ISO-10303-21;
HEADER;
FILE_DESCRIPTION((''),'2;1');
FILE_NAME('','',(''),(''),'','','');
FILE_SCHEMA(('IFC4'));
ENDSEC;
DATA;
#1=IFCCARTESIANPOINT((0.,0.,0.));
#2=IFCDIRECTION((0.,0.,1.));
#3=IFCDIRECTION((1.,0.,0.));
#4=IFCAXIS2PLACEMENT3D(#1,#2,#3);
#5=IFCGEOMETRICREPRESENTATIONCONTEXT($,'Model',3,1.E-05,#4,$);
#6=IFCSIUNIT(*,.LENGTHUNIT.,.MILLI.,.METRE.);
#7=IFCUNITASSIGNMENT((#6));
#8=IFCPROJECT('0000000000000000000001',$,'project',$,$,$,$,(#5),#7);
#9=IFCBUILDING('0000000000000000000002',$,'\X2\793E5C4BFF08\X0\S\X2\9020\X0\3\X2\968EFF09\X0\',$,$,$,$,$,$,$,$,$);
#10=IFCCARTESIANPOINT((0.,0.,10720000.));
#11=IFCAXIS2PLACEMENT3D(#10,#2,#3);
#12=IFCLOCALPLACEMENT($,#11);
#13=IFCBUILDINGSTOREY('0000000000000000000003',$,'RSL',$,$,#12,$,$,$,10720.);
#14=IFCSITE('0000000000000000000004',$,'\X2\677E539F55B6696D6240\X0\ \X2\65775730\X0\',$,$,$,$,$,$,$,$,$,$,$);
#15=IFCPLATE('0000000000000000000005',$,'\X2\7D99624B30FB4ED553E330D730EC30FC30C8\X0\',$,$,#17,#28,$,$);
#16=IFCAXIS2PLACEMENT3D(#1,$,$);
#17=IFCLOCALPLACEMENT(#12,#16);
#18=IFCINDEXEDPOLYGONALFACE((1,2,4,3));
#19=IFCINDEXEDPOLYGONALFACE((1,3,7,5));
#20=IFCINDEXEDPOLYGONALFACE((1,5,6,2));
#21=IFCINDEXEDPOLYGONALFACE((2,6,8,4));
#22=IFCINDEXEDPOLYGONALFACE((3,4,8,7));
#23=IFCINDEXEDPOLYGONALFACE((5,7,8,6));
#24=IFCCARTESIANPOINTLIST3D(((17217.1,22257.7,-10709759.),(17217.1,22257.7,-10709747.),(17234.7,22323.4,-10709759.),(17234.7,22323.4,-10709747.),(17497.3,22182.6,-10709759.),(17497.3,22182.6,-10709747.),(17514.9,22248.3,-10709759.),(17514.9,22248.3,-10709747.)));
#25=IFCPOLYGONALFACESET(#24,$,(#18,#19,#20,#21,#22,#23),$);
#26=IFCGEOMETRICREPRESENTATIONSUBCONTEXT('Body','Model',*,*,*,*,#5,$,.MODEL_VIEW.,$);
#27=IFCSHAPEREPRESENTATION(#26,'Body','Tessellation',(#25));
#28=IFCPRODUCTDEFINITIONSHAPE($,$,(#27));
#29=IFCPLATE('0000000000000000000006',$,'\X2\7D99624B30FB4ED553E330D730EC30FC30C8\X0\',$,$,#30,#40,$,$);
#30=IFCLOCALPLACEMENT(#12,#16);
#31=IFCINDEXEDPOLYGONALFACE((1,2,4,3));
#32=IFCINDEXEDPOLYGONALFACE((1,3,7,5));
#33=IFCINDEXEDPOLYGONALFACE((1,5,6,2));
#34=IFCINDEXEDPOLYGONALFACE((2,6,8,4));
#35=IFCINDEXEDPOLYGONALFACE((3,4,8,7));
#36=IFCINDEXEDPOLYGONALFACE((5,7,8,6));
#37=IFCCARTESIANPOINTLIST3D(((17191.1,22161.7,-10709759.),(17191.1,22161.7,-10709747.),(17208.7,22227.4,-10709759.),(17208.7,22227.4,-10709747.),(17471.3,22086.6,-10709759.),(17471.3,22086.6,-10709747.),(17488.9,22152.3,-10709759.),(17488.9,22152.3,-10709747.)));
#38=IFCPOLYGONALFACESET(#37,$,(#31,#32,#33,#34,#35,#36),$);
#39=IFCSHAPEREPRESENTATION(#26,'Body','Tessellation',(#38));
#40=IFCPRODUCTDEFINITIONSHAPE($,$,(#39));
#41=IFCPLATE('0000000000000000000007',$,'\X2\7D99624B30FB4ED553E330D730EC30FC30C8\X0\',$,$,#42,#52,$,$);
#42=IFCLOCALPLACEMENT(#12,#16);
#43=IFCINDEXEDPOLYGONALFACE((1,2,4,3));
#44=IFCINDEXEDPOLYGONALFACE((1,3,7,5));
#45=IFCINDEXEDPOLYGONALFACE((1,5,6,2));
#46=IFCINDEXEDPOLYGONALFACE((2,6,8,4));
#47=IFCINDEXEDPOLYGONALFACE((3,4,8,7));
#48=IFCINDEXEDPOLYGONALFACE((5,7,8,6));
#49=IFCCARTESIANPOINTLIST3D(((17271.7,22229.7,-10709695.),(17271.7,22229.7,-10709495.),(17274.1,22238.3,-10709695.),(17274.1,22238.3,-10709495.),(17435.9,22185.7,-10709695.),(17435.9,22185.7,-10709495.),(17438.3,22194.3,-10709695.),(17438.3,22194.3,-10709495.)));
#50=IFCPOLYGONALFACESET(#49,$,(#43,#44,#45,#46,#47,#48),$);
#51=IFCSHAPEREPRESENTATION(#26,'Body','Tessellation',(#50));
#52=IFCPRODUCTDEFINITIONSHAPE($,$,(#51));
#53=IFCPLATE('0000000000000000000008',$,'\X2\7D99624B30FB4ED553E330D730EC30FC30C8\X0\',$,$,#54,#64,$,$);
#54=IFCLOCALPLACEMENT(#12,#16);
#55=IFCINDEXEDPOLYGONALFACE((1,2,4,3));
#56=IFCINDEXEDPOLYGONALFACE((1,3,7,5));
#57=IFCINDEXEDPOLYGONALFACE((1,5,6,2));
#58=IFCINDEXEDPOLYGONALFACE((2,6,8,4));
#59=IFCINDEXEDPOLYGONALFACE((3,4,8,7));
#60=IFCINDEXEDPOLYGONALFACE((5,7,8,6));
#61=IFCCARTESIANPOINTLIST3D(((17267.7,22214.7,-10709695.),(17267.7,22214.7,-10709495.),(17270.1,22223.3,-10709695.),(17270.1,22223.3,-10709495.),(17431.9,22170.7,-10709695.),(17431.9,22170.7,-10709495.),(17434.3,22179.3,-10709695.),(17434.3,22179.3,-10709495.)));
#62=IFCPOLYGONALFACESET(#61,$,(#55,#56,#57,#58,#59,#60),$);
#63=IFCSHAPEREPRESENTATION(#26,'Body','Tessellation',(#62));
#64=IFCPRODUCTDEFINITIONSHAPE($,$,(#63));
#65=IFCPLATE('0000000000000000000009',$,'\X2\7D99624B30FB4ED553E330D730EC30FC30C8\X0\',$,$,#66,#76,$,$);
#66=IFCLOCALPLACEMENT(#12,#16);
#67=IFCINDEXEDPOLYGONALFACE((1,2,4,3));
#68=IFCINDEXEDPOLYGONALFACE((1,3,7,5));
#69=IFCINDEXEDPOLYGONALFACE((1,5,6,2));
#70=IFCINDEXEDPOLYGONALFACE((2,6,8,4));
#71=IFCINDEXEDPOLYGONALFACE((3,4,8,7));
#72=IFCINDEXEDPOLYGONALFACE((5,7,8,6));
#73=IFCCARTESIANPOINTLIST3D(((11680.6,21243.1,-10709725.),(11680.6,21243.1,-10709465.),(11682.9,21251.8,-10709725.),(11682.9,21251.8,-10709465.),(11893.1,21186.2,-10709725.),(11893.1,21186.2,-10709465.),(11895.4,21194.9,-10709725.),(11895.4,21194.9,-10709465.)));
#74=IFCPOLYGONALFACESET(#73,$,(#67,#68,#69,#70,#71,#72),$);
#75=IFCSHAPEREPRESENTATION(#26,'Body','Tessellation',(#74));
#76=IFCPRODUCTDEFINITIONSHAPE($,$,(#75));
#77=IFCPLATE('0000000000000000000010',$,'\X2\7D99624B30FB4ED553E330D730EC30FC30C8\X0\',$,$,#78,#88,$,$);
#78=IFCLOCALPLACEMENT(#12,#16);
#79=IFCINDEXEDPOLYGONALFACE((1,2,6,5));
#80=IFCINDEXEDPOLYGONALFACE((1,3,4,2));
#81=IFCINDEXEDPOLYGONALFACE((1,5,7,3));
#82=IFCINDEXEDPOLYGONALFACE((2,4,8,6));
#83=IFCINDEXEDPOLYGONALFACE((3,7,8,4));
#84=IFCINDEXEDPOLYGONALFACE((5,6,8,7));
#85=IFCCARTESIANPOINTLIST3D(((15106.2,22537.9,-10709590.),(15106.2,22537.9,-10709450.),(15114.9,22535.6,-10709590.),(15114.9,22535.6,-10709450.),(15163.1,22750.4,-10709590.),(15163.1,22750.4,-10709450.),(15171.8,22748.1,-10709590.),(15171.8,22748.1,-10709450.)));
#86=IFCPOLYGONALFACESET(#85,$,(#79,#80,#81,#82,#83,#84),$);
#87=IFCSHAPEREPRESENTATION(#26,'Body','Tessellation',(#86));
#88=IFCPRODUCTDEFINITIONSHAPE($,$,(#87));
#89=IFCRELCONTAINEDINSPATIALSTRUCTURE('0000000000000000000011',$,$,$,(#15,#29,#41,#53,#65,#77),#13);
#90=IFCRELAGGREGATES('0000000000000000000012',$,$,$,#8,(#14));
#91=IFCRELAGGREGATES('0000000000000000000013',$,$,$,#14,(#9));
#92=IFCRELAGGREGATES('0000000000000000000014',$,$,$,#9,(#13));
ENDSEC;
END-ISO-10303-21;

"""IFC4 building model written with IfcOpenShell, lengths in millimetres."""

from ifc_helpers import new_model, si_unit, frame, origin, origin_with_axes, place, context, subcontext, project, spatial, rectangle, extrude, element, save


model = new_model("IFC4")

# Units and contexts
model_context = context("Model", 3, precision=1e-05, world=origin_with_axes())
body_context = subcontext(model_context, "Body", "Model", "MODEL_VIEW")
ifc_project = project(units=[si_unit("LENGTHUNIT", "METRE", prefix="MILLI")], contexts=[model_context])

# Site, building, storey
site = spatial("IfcSite", under=ifc_project, Name="松原営業所 敷地")
building = spatial("IfcBuilding", under=site, Name="社屋（S造3階）")
storey_placement = place(None, frame((0.0, 0.0, 10720000.0), z_axis=(0.0, 0.0, 1.0), x_axis=(1.0, 0.0, 0.0)))
storey = spatial("IfcBuildingStorey", under=building, at=storey_placement, Name="RSL", Elevation=10720.0)

# Plates
for number, where, z_axis, x_axis, name in (
    (1, (17225.9, 22290.5, -10709753.0), (0.965926, -0.258819, 0.0), (0.258819, 0.965926, 0.0), "継手・仕口プレート"),
    (2, (17199.9, 22194.5, -10709753.0), (0.965926, -0.258819, 0.0), (0.258819, 0.965926, 0.0), "継手・仕口プレート"),
):
    element("IfcPlate", number, at=place(storey_placement, frame(where, z_axis=z_axis, x_axis=x_axis)), inside=storey, Name=name, context=body_context, shape_type="SweptSolid", body=[
        extrude(rectangle(XDim=68.0, YDim=12.0), origin(), (0.0, 0.0, 1.0), 290.0),
    ])
for number, where, z_axis, x_axis, name in (
    (3, (17272.9, 22234.0, -10709595.0), (0.965926, -0.258819, 0.0), (0.258819, 0.965926, 0.0), "継手・仕口プレート"),
    (4, (17268.9, 22219.0, -10709595.0), (0.965926, -0.258819, 0.0), (0.258819, 0.965926, 0.0), "継手・仕口プレート"),
):
    element("IfcPlate", number, at=place(storey_placement, frame(where, z_axis=z_axis, x_axis=x_axis)), inside=storey, Name=name, context=body_context, shape_type="SweptSolid", body=[
        extrude(rectangle(XDim=9.0, YDim=200.0), origin(), (0.0, 0.0, 1.0), 170.0),
    ])
plate_1_placement = place(storey_placement, frame((11681.7, 21247.5, -10709595.0), z_axis=(0.965926, -0.258819, 0.0), x_axis=(0.258819, 0.965926, 0.0)))
element("IfcPlate", 5, at=plate_1_placement, inside=storey, Name="継手・仕口プレート", context=body_context, shape_type="SweptSolid", body=[
    extrude(rectangle(XDim=9.0, YDim=260.0), origin(), (0.0, 0.0, 1.0), 220.0),
])
plate_2_placement = place(storey_placement, frame((15110.5, 22536.7, -10709520.0), z_axis=(0.258819, 0.965926, 0.0), x_axis=(-0.965926, 0.258819, 0.0)))
element("IfcPlate", 6, at=plate_2_placement, inside=storey, Name="継手・仕口プレート", context=body_context, shape_type="SweptSolid", body=[
    extrude(rectangle(XDim=9.0, YDim=140.0), origin(), (0.0, 0.0, 1.0), 220.0),
])

save(model, "model.ifc")
